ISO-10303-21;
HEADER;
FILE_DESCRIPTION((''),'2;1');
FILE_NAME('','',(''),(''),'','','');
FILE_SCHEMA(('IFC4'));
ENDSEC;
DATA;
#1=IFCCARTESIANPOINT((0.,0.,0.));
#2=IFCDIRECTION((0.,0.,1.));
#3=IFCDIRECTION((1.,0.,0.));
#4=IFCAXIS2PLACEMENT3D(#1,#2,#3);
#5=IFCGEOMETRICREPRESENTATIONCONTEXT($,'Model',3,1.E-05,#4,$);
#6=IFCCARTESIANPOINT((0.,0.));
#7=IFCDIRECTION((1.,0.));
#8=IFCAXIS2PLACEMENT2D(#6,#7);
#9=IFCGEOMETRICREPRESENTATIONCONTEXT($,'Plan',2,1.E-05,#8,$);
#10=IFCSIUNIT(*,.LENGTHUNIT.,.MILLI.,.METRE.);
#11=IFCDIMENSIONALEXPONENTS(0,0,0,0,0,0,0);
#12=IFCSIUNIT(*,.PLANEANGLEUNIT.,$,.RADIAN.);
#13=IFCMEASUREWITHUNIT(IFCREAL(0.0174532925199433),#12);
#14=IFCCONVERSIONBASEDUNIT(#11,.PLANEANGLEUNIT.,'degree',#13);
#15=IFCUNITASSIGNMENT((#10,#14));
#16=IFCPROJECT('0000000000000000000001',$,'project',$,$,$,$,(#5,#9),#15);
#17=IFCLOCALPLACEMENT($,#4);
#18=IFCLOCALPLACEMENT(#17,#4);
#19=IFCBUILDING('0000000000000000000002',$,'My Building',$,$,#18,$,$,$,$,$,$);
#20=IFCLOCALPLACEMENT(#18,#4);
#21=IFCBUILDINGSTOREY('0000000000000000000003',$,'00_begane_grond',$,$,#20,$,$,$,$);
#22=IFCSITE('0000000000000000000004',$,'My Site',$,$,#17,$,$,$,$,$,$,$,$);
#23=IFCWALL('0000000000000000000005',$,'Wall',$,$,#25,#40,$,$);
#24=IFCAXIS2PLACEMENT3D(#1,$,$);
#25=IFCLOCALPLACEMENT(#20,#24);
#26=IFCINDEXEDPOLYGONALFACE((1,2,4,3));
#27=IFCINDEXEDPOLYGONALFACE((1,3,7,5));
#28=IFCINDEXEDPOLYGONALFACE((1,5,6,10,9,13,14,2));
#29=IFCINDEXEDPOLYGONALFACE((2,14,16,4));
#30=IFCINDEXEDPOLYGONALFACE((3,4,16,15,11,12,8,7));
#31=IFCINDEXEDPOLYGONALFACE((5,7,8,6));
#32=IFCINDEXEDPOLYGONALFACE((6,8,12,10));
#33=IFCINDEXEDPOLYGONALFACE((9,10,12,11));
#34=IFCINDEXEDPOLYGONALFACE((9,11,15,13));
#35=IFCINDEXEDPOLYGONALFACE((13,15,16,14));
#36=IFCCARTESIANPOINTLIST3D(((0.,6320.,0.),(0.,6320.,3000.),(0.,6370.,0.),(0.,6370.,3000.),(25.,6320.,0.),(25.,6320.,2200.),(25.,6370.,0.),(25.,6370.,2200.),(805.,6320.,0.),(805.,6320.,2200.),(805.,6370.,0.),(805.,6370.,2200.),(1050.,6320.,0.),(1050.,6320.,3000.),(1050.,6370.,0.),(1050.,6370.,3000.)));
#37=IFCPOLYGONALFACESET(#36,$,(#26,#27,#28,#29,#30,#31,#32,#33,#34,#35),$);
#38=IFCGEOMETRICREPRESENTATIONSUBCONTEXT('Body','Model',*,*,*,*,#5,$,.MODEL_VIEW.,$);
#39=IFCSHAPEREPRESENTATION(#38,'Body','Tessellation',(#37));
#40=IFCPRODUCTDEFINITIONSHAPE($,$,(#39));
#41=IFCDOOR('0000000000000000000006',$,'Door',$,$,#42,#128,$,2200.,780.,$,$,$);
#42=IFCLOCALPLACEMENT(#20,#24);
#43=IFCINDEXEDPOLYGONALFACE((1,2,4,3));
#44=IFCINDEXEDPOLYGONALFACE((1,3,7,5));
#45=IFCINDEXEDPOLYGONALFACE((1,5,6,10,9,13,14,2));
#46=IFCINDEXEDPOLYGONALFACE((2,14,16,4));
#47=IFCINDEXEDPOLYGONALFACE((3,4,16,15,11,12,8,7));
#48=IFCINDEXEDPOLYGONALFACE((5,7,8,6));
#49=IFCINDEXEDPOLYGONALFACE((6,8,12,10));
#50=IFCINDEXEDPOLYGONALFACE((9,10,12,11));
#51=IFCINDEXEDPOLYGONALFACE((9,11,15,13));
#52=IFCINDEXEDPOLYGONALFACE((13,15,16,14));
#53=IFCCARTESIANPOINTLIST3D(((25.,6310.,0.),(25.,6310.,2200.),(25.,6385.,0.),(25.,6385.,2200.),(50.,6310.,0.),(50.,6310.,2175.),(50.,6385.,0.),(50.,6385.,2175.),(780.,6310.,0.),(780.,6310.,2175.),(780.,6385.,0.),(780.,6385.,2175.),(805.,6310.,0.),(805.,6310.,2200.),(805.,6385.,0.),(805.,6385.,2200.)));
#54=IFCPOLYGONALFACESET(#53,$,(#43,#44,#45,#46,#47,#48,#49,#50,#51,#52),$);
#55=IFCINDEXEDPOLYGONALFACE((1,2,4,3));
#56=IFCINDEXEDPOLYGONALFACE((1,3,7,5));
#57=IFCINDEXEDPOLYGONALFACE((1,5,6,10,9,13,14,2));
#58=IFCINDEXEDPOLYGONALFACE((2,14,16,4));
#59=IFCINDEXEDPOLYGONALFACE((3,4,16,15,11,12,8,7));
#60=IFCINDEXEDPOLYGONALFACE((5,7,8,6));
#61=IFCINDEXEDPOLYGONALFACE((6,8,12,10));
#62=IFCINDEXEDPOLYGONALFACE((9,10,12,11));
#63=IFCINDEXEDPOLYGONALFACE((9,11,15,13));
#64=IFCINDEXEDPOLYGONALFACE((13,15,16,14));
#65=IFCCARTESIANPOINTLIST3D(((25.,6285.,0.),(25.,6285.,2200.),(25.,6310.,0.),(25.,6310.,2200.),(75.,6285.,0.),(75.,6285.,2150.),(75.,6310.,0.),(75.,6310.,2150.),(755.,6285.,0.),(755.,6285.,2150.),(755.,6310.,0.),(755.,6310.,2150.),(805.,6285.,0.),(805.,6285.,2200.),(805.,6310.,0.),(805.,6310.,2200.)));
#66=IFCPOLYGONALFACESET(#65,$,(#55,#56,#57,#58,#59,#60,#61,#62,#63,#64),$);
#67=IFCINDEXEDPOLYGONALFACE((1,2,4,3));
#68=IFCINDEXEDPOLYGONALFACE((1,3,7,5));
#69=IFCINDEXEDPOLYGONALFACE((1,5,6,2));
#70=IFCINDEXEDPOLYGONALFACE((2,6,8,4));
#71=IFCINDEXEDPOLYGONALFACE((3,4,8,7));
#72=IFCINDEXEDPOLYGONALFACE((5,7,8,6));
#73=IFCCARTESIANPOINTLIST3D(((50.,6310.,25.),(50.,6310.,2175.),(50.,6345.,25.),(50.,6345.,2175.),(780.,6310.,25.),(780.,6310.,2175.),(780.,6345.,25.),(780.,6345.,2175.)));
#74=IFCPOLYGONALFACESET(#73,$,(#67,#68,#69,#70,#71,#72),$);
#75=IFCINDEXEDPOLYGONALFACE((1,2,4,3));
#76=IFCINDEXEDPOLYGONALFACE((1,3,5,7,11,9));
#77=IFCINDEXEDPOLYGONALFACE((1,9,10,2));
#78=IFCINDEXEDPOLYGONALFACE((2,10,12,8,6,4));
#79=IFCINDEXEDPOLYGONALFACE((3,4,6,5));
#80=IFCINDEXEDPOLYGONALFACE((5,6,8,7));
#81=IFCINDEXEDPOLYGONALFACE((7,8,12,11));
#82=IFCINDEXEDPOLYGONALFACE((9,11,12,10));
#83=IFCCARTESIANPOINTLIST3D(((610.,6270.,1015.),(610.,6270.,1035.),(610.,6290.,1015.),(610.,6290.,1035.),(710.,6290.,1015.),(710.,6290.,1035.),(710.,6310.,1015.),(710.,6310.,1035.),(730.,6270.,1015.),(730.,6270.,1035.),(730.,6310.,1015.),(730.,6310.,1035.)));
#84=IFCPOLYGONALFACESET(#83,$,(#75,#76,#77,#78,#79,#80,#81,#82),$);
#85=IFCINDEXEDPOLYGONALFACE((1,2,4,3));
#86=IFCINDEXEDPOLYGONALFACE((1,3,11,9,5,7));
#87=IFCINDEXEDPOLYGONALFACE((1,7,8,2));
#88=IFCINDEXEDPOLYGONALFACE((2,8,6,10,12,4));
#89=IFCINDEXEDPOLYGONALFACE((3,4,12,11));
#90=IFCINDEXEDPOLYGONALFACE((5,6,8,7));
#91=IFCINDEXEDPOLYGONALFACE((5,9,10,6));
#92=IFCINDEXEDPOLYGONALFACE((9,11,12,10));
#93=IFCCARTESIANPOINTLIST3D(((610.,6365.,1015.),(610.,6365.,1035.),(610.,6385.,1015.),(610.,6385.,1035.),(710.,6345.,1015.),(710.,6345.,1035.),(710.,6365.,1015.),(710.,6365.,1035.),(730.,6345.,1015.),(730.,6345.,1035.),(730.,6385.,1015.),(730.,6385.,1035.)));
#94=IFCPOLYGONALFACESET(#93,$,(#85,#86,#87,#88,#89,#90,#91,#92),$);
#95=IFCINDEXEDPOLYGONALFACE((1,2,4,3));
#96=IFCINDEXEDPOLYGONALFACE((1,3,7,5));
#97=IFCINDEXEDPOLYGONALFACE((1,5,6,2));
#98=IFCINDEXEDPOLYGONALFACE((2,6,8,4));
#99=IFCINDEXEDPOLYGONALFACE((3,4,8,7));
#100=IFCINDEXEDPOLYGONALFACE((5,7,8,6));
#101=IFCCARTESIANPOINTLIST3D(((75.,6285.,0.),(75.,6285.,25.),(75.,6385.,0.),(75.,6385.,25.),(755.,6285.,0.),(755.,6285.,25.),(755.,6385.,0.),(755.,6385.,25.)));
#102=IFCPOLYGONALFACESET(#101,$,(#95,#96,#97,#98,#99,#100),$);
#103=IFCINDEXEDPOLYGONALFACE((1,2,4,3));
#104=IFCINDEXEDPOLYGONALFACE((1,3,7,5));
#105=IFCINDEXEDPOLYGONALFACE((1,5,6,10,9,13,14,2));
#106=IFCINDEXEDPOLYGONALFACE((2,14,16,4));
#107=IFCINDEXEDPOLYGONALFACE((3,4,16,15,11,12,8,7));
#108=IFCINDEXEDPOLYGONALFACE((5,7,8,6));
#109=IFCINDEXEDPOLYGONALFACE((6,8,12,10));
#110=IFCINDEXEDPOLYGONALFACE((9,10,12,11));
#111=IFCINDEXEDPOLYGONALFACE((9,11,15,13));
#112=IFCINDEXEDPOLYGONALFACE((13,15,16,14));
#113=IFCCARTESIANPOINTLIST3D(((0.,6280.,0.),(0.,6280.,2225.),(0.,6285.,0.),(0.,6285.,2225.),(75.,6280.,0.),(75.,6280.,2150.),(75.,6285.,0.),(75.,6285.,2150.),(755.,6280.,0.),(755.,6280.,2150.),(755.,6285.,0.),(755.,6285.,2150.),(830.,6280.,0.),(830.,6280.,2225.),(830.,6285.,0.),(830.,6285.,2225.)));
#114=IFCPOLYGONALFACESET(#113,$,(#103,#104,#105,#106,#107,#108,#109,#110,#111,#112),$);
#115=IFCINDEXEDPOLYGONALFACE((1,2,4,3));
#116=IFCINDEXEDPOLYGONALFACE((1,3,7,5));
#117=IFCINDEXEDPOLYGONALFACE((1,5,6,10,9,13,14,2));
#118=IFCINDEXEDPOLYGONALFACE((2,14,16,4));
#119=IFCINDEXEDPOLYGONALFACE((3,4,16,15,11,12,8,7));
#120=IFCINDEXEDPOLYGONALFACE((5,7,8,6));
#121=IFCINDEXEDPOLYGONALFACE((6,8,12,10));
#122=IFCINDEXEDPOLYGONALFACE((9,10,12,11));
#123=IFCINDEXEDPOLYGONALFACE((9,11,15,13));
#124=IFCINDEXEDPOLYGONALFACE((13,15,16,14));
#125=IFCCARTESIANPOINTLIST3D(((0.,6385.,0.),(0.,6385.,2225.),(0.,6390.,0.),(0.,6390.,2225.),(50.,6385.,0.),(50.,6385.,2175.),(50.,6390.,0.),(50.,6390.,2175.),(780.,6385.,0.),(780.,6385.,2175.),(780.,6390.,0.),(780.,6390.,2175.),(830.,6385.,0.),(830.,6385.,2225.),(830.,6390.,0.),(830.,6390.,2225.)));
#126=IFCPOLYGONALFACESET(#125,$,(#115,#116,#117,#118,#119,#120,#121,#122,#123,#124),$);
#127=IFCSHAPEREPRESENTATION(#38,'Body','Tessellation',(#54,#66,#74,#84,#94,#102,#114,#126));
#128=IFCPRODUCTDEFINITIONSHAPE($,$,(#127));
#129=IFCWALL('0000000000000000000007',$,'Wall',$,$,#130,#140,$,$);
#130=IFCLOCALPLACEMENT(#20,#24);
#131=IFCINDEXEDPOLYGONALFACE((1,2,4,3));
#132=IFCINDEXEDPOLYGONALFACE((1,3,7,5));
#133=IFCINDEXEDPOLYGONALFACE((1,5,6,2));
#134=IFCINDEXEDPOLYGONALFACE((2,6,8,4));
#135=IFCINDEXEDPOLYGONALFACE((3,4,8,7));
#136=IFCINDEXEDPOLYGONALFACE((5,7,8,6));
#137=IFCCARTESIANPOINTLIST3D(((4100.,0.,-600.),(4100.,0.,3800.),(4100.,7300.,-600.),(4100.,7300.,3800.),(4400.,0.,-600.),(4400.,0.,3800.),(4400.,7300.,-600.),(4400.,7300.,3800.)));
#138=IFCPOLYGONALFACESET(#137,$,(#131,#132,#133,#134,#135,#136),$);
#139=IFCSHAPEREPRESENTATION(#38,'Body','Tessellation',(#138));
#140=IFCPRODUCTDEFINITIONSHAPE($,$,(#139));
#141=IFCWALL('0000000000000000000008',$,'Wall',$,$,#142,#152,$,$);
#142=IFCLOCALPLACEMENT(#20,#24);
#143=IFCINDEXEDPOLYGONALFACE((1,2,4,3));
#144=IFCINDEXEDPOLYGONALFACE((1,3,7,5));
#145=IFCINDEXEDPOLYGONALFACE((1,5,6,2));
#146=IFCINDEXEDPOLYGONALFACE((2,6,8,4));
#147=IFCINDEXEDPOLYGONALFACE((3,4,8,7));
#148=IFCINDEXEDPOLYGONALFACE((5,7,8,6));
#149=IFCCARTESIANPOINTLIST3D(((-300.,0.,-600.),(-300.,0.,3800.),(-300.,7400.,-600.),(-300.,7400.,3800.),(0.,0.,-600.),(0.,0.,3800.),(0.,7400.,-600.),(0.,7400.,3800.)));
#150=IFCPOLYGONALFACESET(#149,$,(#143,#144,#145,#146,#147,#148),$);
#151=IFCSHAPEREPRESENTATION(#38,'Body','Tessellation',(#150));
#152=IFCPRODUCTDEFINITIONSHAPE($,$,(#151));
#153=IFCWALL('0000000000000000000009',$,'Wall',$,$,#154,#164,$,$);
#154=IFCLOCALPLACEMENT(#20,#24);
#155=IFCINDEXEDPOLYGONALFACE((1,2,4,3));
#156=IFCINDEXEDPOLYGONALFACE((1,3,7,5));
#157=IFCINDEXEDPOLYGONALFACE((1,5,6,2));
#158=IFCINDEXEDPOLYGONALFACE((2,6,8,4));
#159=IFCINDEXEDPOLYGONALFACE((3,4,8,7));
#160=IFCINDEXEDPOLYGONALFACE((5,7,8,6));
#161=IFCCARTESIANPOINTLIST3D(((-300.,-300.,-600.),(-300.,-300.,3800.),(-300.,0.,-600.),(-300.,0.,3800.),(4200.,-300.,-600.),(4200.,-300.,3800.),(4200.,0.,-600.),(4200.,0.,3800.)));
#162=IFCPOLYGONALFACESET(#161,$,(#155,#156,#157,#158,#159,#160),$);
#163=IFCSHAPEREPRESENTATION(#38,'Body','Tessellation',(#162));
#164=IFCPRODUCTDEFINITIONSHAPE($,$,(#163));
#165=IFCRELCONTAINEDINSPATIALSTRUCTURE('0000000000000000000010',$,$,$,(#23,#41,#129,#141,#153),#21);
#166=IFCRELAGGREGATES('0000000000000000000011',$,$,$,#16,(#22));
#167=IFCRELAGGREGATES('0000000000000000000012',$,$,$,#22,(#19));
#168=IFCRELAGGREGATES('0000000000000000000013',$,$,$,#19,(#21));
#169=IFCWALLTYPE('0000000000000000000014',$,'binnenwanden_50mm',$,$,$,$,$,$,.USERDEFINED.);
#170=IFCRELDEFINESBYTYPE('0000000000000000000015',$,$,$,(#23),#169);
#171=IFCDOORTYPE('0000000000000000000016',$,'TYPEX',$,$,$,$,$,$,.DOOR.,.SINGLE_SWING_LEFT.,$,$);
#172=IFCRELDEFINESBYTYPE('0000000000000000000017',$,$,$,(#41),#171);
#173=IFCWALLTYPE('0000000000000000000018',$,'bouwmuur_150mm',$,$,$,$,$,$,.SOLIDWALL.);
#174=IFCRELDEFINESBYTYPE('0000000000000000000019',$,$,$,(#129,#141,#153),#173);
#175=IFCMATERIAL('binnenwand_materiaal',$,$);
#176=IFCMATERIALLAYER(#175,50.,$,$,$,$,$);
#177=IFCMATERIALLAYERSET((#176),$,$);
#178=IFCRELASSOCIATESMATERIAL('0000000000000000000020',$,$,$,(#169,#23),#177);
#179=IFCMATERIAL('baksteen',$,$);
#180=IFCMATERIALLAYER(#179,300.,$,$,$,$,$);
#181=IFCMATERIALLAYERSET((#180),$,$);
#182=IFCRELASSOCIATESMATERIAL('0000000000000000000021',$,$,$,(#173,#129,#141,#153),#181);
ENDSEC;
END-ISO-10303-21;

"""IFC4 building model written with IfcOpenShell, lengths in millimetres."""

from ifc_helpers import new_model, entity, si_unit, converted_unit, frame, origin_with_axes, origin_2d_with_axis, place, context, subcontext, project, spatial, line, indexed_curve, outline, extrude, shape, source, transform, mapped, material, layer, layer_set, layer_usage, type_object, type_shapes, element, fill, save


model = new_model("IFC4")

# Units and contexts
model_context = context("Model", 3, precision=1e-05, world=origin_with_axes())
plan_context = context("Plan", 2, precision=1e-05, world=origin_2d_with_axis())
body_context_1 = subcontext(model_context, "Body", "Model", "MODEL_VIEW")
body_context_2 = subcontext(plan_context, "Body", "Plan", "PLAN_VIEW")
ifc_project = project(units=[si_unit("LENGTHUNIT", "METRE", prefix="MILLI"), converted_unit("PLANEANGLEUNIT", "degree", entity("IfcReal", 0.0174532925199433), si_unit("PLANEANGLEUNIT", "RADIAN"), dimensions=[0, 0, 0, 0, 0, 0, 0])], contexts=[model_context, plan_context])

# Site, building, storey
site_placement = place(None, origin_with_axes())
site = spatial("IfcSite", under=ifc_project, at=site_placement, Name="My Site")
building_placement = place(site_placement, origin_with_axes())
building = spatial("IfcBuilding", under=site, at=building_placement, Name="My Building")
storey_placement = place(building_placement, origin_with_axes())
storey = spatial("IfcBuildingStorey", under=building, at=storey_placement, Name="00_begane_grond")

# Shared definitions
ifc_material_1 = material(Name="baksteen")

# Shared definitions
shared_shape_1 = source(origin_with_axes(), body_context_1, "Body", "SweptSolid", [
    extrude(outline(indexed_curve([(0.0, 0.0), (780.0, 0.0), (780.0, 2200.0), (0.0, 2200.0)], segments=[line(1, 2, 3, 4, 1)])), frame((0.0, -100.0, 0.0), z_axis=(0.0, -1.0, 0.0), x_axis=(1.0, 0.0, 0.0)), (0.0, 0.0, -1.0), 300.0),
])
door_type = type_object("IfcDoorType", Name="TYPEX", OperationType="SINGLE_SWING_LEFT", PredefinedType="DOOR")
shared_shape_2 = source(origin_with_axes(), body_context_1, "Body", "SweptSolid", [
    extrude(outline(indexed_curve([(0.0, 0.0), (0.0, 2200.0), (780.0, 2200.0), (780.0, 0.0), (755.0, 0.0), (755.0, 2175.0), (25.0, 2175.0), (25.0, 0.0)], segments=[line(1, 2, 3, 4, 5, 6, 7, 8, 1)])), frame((0.0, 25.0, 0.0), z_axis=(0.0, -1.0, 0.0), x_axis=(1.0, 0.0, 0.0)), (0.0, 0.0, -1.0), 75.0),
    extrude(outline(indexed_curve([(0.0, 0.0), (0.0, 2200.0), (780.0, 2200.0), (780.0, 0.0), (730.0, 0.0), (730.0, 2150.0), (50.0, 2150.0), (50.0, 0.0)], segments=[line(1, 2, 3, 4, 5, 6, 7, 8, 1)])), frame((0.0, 0.0, 0.0), z_axis=(0.0, -1.0, 0.0), x_axis=(1.0, 0.0, 0.0)), (0.0, 0.0, -1.0), 25.0),
    extrude(outline(indexed_curve([(0.0, 0.0), (730.0, 0.0), (730.0, 35.0), (0.0, 35.0)], segments=[line(1, 2, 3, 4, 1)])), frame((25.0, 25.0, 25.0), z_axis=(0.0, 0.0, 1.0), x_axis=(1.0, 0.0, 0.0)), (0.0, 0.0, 1.0), 2150.0),
    extrude(outline(indexed_curve([(0.0, 0.0), (0.0, -40.0), (-120.0, -40.0), (-120.0, -20.0), (-20.0, -20.0), (-20.0, 0.0)], segments=[line(1, 2, 3, 4, 5, 6, 1)])), frame((705.0, 25.0, 1015.0), z_axis=(0.0, 0.0, 1.0), x_axis=(1.0, 0.0, 0.0)), (0.0, 0.0, 1.0), 20.0),
    extrude(outline(indexed_curve([(0.0, 0.0), (0.0, 40.0), (-120.0, 40.0), (-120.0, 20.0), (-20.0, 20.0), (-20.0, 0.0)], segments=[line(1, 2, 3, 4, 5, 6, 1)])), frame((705.0, 60.0, 1015.0), z_axis=(0.0, 0.0, 1.0), x_axis=(1.0, 0.0, 0.0)), (0.0, 0.0, 1.0), 20.0),
    extrude(outline(indexed_curve([(0.0, 0.0), (680.0, 0.0), (680.0, 100.0), (0.0, 100.0)], segments=[line(1, 2, 3, 4, 1)])), frame((50.0, 0.0, 0.0), z_axis=(0.0, 0.0, 1.0), x_axis=(1.0, 0.0, 0.0)), (0.0, 0.0, 1.0), 25.0),
    extrude(outline(indexed_curve([(0.0, 0.0), (0.0, 2225.0), (830.0, 2225.0), (830.0, 0.0), (755.0, 0.0), (755.0, 2150.0), (75.0, 2150.0), (75.0, 0.0)], segments=[line(1, 2, 3, 4, 5, 6, 7, 8, 1)])), frame((-25.0, -5.0, 0.0), z_axis=(0.0, -1.0, 0.0), x_axis=(1.0, 0.0, 0.0)), (0.0, 0.0, -1.0), 5.0),
    extrude(outline(indexed_curve([(0.0, 0.0), (0.0, 2225.0), (830.0, 2225.0), (830.0, 0.0), (780.0, 0.0), (780.0, 2175.0), (50.0, 2175.0), (50.0, 0.0)], segments=[line(1, 2, 3, 4, 5, 6, 7, 8, 1)])), frame((-25.0, 100.0, 0.0), z_axis=(0.0, -1.0, 0.0), x_axis=(1.0, 0.0, 0.0)), (0.0, 0.0, -1.0), 5.0),
])
shared_shape_3 = source(origin_with_axes(), body_context_2, "Body", "Curve2D", [
    entity("IfcIndexedPolyCurve", entity("IfcCartesianPointList2D", [[0.0, 0.0], [0.0, 100.0], [25.0, 100.0], [25.0, 25.0], [50.0, 25.0], [50.0, 0.0]]), [entity("IfcLineIndex", [1, 2, 3, 4, 5, 6, 1])]),
    entity("IfcIndexedPolyCurve", entity("IfcCartesianPointList2D", [[780.0, 0.0], [780.0, 100.0], [755.0, 100.0], [755.0, 25.0], [730.0, 25.0], [730.0, 0.0]]), [entity("IfcLineIndex", [1, 2, 3, 4, 5, 6, 1])]),
    entity("IfcTrimmedCurve", entity("IfcEllipse", entity("IfcAxis2Placement2D", entity("IfcCartesianPoint", [60.0, 100.0]), entity("IfcDirection", [1.0, 0.0])), 695.0, 730.0), [entity("IfcCartesianPoint", [755.0, 100.0])], [entity("IfcCartesianPoint", [60.0, 830.0])], True, "CARTESIAN"),
    entity("IfcIndexedPolyCurve", entity("IfcCartesianPointList2D", [[25.0, 100.0], [60.0, 100.0], [60.0, 830.0], [25.0, 830.0]]), [entity("IfcLineIndex", [1, 2, 3, 4, 1])]),
])
type_shapes(door_type, [shared_shape_2, shared_shape_3])

# Shared definitions
ifc_material_2 = material(Name="binnenwand_materiaal")
ifc_layer_1 = layer(ifc_material_2, 50.0)
ifc_layer_set_1 = layer_set([ifc_layer_1])
wall_type_1 = type_object("IfcWallType", Name="binnenwanden_50mm", PredefinedType="USERDEFINED", material=ifc_layer_set_1)

# Wall, opening, door
ifc_layer_usage_1 = layer_usage(ifc_layer_set_1, "AXIS2", "POSITIVE", 0.0)
wall_1_placement = place(storey_placement, frame((1050.0, 6370.0, 0.0), z_axis=(0.0, 0.0, 1.0), x_axis=(-1.0, 0.0, 0.0)))
wall_1 = element("IfcWall", 1, at=wall_1_placement, inside=storey, type_object=wall_type_1, material=ifc_layer_usage_1, Name="Wall", context=body_context_1, shape_type="SweptSolid", body=[
    extrude(outline(indexed_curve([(0.0, 0.0), (0.0, 50.0), (1050.0, 50.0), (1050.0, 0.0), (0.0, 0.0)], self_intersect=False)), origin_with_axes(), (0.0, 0.0, 1.0), 3000.0),
])
opening_1_placement = place(wall_1_placement, frame((1025.0, 85.0, 0.0), z_axis=(0.0, 0.0, 1.0), x_axis=(-1.0, 0.0, 0.0)))
opening_1 = element("IfcOpeningElement", 2, at=opening_1_placement, cuts=wall_1, PredefinedType="OPENING", context=body_context_1, shape_type="MappedRepresentation", body=[
    mapped(shared_shape_1, transform((0.0, 0.0, 0.0), x_axis=(1.0, 0.0, 0.0), y_axis=(0.0, 1.0, 0.0), z_axis=(0.0, 0.0, 1.0), scale=1.0)),
])
door_1_placement = place(opening_1_placement, frame((0.0, 0.0, 0.0), z_axis=(0.0, 0.0, 1.0), x_axis=(1.0, 0.0, 0.0)))
door_1 = element("IfcDoor", 3, at=door_1_placement, inside=storey, type_object=door_type, Name="Door", OverallHeight=2200.0, OverallWidth=780.0, shapes=[
    shape(body_context_1, "Body", "MappedRepresentation", [mapped(shared_shape_2, transform((0.0, 0.0, 0.0), x_axis=(1.0, 0.0, 0.0), y_axis=(0.0, 1.0, 0.0), z_axis=(0.0, 0.0, 1.0), scale=1.0))]),
    shape(body_context_2, "Body", "MappedRepresentation", [mapped(shared_shape_3, transform((0.0, 0.0, 0.0), x_axis=(1.0, 0.0, 0.0), y_axis=(0.0, 1.0, 0.0), z_axis=(0.0, 0.0, 1.0), scale=1.0))]),
])
fill(opening_1, door_1)

# Walls
ifc_layer_2 = layer(ifc_material_1, 300.0)
ifc_layer_set_2 = layer_set([ifc_layer_2])
ifc_layer_usage_2 = layer_usage(ifc_layer_set_2, "AXIS2", "POSITIVE", 0.0)
wall_type_2 = type_object("IfcWallType", Name="bouwmuur_150mm", PredefinedType="SOLIDWALL", material=ifc_layer_set_2)
wall_2_placement = place(storey_placement, frame((4100.0, 7300.0, -600.0), z_axis=(0.0, 0.0, 1.0), x_axis=(0.0, -1.0, 0.0)))
element("IfcWall", 4, at=wall_2_placement, inside=storey, type_object=wall_type_2, material=ifc_layer_usage_2, Name="Wall", context=body_context_1, shape_type="SweptSolid", body=[
    extrude(outline(indexed_curve([(0.0, 0.0), (0.0, 300.0), (7300.0, 300.0), (7300.0, 0.0), (0.0, 0.0)], self_intersect=False)), origin_with_axes(), (0.0, 0.0, 1.0), 4400.0),
])
ifc_layer_usage_3 = layer_usage(ifc_layer_set_2, "AXIS2", "POSITIVE", 0.0)
wall_3_placement = place(storey_placement, frame((0.0, 0.0, -600.0), z_axis=(0.0, 0.0, 1.0), x_axis=(0.0, 1.0, 0.0)))
element("IfcWall", 5, at=wall_3_placement, inside=storey, type_object=wall_type_2, material=ifc_layer_usage_3, Name="Wall", context=body_context_1, shape_type="SweptSolid", body=[
    extrude(outline(indexed_curve([(0.0, 0.0), (0.0, 300.0), (7400.0, 300.0), (7400.0, 0.0), (0.0, 0.0)], self_intersect=False)), origin_with_axes(), (0.0, 0.0, 1.0), 4400.0),
])
ifc_layer_usage_4 = layer_usage(ifc_layer_set_2, "AXIS2", "POSITIVE", 0.0)
wall_4_placement = place(storey_placement, frame((4200.0, 0.0, -600.0), z_axis=(0.0, 0.0, 1.0), x_axis=(-1.0, 0.0, 0.0)))
element("IfcWall", 6, at=wall_4_placement, inside=storey, type_object=wall_type_2, material=ifc_layer_usage_4, Name="Wall", context=body_context_1, shape_type="SweptSolid", body=[
    extrude(outline(indexed_curve([(0.0, 0.0), (0.0, 300.0), (4500.0, 300.0), (4500.0, 0.0), (0.0, 0.0)], self_intersect=False)), origin_with_axes(), (0.0, 0.0, 1.0), 4400.0),
])

save(model, "model.ifc")
